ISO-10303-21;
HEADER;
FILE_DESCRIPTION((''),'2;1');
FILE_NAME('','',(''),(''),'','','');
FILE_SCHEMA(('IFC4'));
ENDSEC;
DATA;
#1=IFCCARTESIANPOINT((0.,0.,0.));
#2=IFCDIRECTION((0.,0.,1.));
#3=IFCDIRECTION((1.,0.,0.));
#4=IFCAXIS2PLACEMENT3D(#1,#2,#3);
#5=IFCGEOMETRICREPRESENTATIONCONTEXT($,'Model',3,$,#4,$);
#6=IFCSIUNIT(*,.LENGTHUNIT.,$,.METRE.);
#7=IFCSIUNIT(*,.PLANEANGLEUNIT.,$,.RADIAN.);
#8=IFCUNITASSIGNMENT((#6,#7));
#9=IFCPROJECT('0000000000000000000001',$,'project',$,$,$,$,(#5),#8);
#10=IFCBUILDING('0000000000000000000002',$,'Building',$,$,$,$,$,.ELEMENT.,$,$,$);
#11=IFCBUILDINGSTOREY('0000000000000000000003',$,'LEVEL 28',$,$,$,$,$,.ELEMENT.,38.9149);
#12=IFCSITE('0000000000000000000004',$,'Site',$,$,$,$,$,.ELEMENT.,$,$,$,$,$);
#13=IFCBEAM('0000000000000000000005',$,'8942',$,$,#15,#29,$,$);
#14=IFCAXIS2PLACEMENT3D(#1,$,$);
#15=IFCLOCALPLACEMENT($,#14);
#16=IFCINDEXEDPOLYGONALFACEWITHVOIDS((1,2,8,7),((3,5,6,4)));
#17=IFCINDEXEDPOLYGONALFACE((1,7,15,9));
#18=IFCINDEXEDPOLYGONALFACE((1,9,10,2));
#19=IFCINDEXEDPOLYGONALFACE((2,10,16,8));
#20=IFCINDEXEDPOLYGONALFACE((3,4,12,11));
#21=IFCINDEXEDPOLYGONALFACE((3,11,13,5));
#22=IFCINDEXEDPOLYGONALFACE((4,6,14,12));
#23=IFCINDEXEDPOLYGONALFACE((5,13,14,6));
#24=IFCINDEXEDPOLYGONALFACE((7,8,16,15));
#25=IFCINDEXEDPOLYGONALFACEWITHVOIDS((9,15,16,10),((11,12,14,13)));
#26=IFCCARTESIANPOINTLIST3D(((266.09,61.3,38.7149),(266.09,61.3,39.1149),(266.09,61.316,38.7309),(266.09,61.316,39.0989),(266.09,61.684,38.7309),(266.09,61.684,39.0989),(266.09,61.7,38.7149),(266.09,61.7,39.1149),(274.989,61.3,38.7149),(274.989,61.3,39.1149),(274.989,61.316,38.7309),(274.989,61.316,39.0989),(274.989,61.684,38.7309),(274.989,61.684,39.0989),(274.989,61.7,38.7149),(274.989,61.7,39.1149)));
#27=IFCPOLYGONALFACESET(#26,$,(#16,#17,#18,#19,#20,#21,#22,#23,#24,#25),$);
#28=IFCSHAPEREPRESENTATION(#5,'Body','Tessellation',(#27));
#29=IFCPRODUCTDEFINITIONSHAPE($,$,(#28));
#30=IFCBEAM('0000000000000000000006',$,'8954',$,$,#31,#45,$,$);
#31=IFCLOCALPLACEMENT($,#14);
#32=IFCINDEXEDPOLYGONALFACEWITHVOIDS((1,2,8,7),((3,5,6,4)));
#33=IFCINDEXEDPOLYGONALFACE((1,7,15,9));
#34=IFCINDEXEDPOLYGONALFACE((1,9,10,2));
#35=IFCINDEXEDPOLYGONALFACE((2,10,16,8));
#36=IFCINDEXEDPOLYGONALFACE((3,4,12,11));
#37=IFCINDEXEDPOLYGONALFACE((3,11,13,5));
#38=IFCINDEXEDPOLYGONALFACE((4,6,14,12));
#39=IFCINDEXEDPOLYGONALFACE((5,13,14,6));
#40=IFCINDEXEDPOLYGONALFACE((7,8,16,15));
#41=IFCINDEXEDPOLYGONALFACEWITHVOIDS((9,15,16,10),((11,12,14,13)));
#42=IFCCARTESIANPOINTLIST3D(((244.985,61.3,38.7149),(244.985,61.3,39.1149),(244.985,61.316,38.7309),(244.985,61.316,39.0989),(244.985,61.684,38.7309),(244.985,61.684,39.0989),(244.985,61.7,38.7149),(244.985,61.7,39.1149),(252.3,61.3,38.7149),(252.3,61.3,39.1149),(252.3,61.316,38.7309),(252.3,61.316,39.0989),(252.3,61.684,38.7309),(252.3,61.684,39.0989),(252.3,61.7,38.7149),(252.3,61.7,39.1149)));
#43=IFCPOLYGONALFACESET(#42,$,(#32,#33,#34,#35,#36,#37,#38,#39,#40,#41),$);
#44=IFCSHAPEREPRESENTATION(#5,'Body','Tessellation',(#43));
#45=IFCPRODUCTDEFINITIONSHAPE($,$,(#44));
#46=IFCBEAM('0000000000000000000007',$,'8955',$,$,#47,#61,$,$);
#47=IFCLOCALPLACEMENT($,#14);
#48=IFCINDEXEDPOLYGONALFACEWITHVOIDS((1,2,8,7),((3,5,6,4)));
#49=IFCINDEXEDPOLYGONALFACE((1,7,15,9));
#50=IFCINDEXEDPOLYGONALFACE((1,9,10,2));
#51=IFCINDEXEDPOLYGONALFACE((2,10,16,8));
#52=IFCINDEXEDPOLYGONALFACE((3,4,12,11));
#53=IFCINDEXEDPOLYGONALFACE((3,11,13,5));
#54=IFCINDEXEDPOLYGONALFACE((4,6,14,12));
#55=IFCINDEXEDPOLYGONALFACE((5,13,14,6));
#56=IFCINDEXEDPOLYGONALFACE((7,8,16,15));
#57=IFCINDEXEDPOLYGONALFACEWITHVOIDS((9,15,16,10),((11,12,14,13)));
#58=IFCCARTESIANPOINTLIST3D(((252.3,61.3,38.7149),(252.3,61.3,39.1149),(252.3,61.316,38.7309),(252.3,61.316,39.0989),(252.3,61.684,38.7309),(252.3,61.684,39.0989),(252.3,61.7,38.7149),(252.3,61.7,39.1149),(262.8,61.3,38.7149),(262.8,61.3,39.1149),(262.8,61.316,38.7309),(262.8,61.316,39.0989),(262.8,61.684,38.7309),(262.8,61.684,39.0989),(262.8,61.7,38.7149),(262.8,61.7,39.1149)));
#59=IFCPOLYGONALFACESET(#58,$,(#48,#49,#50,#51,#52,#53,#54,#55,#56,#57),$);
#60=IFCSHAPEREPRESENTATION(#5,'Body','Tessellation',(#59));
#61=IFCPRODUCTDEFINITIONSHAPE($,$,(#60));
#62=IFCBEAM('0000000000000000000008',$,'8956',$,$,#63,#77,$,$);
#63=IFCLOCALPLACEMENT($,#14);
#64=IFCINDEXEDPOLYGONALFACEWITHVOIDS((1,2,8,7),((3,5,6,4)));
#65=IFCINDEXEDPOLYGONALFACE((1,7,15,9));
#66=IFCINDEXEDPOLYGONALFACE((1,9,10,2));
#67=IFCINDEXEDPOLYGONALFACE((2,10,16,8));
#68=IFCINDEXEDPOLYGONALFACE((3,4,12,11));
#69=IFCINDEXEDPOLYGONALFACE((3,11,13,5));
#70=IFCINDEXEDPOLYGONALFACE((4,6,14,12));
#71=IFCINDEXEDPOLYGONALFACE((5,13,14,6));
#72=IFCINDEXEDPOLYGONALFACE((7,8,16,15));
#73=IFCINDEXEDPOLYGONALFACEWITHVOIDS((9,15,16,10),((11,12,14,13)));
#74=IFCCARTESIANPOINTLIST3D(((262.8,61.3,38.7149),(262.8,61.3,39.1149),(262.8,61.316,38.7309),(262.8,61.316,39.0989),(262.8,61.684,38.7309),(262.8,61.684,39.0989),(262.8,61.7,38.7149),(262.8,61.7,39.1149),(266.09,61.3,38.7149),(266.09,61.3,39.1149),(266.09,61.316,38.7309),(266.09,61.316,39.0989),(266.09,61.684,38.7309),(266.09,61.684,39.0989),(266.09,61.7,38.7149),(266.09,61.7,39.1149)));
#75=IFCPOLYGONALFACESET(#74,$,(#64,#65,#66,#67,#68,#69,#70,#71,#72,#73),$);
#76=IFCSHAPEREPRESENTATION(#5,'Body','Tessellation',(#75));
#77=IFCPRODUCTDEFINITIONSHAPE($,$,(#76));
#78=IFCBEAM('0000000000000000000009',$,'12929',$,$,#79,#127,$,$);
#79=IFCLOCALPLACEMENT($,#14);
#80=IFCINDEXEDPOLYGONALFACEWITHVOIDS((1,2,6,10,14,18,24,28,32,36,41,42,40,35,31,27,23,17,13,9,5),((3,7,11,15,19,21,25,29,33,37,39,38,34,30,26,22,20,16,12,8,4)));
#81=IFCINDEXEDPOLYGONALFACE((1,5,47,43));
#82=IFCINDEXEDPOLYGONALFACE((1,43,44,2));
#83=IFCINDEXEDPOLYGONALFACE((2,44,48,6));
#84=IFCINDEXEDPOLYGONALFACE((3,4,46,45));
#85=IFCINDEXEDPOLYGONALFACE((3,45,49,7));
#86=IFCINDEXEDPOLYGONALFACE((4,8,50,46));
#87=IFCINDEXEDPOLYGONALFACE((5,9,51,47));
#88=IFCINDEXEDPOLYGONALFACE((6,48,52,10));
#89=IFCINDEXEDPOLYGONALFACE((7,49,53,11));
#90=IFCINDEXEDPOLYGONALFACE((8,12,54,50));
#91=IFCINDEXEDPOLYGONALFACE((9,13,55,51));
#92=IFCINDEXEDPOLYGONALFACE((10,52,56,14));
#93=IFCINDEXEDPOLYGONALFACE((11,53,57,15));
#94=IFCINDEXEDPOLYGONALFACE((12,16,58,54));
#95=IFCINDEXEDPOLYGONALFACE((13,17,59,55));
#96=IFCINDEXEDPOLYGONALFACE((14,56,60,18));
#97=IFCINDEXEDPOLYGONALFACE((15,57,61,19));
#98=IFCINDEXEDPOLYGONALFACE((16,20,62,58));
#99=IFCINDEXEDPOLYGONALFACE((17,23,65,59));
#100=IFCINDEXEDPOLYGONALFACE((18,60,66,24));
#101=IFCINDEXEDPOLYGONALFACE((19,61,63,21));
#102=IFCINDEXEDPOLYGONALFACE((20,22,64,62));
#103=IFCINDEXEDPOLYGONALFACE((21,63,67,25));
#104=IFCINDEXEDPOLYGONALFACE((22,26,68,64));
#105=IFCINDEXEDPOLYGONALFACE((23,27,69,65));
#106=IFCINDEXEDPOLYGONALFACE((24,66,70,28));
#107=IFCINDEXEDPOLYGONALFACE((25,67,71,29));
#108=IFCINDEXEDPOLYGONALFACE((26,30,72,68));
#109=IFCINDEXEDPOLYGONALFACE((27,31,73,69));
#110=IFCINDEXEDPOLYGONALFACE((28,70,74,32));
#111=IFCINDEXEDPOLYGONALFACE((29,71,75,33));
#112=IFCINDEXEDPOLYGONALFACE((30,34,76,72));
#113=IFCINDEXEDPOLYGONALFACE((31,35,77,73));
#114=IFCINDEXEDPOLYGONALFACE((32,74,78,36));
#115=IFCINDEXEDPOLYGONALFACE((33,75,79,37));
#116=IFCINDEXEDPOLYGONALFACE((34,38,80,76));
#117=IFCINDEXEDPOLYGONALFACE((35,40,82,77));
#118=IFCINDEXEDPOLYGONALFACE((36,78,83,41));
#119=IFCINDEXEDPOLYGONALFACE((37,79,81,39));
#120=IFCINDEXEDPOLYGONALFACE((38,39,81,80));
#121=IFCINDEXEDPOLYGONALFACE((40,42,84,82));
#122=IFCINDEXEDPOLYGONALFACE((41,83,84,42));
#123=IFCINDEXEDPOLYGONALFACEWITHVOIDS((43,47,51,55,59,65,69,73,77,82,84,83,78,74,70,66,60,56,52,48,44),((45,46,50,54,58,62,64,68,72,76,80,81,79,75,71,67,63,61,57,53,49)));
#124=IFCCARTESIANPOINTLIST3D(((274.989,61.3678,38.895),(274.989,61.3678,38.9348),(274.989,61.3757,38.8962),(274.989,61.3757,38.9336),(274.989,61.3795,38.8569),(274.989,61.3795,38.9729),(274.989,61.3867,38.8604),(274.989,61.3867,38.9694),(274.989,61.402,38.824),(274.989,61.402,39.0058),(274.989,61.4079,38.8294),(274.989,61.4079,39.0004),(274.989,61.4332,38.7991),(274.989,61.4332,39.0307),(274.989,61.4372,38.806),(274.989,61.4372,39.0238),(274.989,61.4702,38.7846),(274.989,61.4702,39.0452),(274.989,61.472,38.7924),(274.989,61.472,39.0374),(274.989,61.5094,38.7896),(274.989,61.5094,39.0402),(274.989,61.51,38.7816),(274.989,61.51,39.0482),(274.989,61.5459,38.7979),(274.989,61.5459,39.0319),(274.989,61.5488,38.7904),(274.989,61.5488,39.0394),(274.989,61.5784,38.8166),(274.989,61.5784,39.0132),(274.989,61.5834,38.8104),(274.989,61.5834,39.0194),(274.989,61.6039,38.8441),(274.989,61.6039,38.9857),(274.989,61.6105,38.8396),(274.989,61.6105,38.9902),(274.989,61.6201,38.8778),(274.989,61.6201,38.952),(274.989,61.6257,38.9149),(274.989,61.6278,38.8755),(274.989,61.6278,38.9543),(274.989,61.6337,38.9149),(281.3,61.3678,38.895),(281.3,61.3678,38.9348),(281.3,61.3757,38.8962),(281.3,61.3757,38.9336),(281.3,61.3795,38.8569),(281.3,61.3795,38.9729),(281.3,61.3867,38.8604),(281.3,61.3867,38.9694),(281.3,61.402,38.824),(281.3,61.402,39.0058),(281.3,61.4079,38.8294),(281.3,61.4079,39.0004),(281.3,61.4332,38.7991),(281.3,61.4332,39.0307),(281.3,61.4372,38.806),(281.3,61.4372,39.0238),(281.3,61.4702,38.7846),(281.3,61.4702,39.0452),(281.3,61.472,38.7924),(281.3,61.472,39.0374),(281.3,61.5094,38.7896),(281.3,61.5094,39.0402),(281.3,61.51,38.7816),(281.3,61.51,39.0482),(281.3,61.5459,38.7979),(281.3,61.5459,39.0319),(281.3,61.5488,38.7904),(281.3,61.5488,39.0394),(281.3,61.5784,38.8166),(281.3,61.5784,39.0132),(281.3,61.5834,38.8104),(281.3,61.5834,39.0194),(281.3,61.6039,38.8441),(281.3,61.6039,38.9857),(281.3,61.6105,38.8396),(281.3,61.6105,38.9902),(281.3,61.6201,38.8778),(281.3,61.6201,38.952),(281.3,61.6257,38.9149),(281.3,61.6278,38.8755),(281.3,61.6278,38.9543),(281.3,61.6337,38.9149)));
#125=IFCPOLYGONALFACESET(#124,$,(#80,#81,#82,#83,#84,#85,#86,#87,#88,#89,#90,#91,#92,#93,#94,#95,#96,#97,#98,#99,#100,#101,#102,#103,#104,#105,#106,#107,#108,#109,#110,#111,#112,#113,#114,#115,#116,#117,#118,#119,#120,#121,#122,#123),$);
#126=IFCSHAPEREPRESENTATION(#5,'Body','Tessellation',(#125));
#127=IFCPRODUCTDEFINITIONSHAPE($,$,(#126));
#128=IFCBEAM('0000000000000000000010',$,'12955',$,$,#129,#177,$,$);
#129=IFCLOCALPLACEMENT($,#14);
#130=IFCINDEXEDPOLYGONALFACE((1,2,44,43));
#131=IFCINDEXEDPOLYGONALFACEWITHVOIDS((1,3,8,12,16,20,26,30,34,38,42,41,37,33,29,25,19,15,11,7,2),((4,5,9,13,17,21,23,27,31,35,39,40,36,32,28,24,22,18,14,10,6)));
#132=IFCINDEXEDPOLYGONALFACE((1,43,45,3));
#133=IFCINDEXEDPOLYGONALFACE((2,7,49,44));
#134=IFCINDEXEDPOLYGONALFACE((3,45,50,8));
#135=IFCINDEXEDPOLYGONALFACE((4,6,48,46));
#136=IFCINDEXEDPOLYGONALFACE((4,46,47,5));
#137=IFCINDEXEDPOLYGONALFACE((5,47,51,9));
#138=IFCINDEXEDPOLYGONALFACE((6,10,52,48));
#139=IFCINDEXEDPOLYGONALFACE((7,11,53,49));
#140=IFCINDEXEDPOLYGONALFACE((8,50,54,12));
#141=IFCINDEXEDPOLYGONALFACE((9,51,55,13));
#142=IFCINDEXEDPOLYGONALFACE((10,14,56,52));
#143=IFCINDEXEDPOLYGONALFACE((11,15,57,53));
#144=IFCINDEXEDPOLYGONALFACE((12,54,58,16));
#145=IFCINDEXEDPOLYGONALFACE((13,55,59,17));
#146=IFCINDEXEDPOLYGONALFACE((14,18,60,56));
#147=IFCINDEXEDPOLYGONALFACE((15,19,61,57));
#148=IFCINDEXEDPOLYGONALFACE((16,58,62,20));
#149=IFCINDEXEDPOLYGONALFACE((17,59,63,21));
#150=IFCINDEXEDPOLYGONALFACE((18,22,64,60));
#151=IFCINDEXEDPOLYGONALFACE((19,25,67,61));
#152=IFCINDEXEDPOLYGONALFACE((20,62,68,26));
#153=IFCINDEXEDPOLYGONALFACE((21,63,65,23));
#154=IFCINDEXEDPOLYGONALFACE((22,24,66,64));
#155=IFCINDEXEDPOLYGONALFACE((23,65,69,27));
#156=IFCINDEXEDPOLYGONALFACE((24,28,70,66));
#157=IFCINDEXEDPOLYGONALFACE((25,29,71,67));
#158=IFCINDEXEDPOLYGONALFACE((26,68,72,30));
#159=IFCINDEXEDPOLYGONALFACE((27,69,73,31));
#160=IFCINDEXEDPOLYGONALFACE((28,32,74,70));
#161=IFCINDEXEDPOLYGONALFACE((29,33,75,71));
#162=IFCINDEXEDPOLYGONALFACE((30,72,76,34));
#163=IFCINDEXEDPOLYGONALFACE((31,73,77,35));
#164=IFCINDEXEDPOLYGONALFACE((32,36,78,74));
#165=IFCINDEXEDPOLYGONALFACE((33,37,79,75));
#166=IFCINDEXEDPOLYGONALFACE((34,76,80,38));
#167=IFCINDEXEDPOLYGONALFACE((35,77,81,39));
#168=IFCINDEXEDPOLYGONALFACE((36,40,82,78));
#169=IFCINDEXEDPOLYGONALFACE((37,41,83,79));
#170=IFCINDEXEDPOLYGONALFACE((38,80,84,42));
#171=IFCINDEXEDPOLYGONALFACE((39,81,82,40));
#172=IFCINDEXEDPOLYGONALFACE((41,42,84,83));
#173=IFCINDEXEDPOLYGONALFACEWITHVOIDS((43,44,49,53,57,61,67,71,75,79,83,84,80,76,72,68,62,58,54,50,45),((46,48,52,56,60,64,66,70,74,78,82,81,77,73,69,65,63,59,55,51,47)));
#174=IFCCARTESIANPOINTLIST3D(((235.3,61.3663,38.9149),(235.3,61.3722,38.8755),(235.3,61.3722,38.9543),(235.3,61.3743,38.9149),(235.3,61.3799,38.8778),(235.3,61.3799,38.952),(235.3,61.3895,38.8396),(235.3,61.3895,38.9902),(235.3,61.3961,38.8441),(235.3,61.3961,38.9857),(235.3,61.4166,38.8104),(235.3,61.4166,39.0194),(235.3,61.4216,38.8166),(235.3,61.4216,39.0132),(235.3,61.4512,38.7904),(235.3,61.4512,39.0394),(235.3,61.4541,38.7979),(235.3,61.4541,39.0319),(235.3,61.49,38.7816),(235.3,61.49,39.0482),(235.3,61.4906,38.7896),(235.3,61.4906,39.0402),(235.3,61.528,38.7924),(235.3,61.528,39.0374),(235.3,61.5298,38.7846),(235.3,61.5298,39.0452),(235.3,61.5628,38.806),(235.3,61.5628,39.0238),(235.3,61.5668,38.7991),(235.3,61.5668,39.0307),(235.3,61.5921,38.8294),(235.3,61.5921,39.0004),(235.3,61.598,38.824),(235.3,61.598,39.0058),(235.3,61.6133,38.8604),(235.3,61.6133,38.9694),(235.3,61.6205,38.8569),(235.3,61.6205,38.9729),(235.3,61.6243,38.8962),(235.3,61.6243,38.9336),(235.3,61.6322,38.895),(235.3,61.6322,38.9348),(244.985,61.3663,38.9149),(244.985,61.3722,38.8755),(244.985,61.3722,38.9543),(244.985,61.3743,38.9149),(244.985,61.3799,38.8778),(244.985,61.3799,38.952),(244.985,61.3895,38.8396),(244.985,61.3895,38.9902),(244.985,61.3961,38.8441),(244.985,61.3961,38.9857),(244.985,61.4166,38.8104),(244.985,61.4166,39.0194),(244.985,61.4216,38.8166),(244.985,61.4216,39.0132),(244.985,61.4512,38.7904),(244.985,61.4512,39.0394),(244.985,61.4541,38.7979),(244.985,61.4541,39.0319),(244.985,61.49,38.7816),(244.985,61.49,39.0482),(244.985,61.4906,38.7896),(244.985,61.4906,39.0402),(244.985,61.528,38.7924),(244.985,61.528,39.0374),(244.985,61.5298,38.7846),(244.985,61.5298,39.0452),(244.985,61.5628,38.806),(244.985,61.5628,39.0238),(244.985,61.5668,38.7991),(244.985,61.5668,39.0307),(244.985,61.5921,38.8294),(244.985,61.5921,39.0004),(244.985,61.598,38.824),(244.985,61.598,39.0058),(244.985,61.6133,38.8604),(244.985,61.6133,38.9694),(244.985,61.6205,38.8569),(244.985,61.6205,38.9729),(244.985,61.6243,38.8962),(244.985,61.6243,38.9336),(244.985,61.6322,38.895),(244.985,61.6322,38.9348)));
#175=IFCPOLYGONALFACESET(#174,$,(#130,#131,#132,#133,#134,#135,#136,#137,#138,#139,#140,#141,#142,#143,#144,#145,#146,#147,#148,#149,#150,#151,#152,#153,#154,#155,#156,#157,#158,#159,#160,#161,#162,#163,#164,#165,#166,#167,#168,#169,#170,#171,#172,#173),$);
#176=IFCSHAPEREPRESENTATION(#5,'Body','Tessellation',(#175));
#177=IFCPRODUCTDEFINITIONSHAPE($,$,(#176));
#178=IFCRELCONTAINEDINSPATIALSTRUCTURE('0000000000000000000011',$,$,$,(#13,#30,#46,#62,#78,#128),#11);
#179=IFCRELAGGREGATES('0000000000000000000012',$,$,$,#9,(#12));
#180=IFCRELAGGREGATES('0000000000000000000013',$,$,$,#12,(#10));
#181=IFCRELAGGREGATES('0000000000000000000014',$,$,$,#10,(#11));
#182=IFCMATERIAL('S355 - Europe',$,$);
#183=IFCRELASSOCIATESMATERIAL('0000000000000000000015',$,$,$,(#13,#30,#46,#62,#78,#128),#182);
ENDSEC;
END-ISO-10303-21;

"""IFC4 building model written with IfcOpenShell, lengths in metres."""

from ifc_helpers import new_model, si_unit, frame, origin_with_axes, origin_2d_with_axis, place, context, project, spatial, hollow_rectangle, hollow_circle, extrude, material, material_profile, profile_set, profile_usage, element, save


model = new_model("IFC4")

# Units and contexts
model_context = context("Model", 3, world=origin_with_axes())
ifc_project = project(units=[si_unit("LENGTHUNIT", "METRE"), si_unit("PLANEANGLEUNIT", "RADIAN")], contexts=[model_context])

# Site, building, storey
site = spatial("IfcSite", under=ifc_project, Name="Site", CompositionType="ELEMENT")
building = spatial("IfcBuilding", under=site, Name="Building", CompositionType="ELEMENT")
storey = spatial("IfcBuildingStorey", under=building, Name="LEVEL 28", CompositionType="ELEMENT", Elevation=38.9149)

# Beams
ifc_material = material(Name="S355 - Europe")
ifc_material_profile_1 = material_profile(ifc_material, hollow_rectangle(XDim=0.4, YDim=0.4, WallThickness=0.016, at=origin_2d_with_axis()))
ifc_profile_set_1 = profile_set([ifc_material_profile_1])
ifc_profile_usage_1 = profile_usage(ifc_profile_set_1, cardinal=10)
beam_1_placement = place(None, frame((274.989, 61.5, 38.9149), z_axis=(-1.0, 0.0, 0.0), x_axis=(0.0, -1.0, 0.0)))
element("IfcBeam", 1, at=beam_1_placement, inside=storey, material=ifc_profile_usage_1, Name="8942", context=model_context, shape_type="SweptSolid", body=[
    extrude(hollow_rectangle(XDim=0.4, YDim=0.4, WallThickness=0.016, at=origin_2d_with_axis()), origin_with_axes(), (0.0, 0.0, 1.0), 8.899),
])
ifc_material_profile_2 = material_profile(ifc_material, hollow_rectangle(XDim=0.4, YDim=0.4, WallThickness=0.016, at=origin_2d_with_axis()))
ifc_profile_set_2 = profile_set([ifc_material_profile_2])
ifc_profile_usage_2 = profile_usage(ifc_profile_set_2, cardinal=10)
beam_2_placement = place(None, frame((252.3, 61.5, 38.9149), z_axis=(-1.0, 0.0, 0.0), x_axis=(0.0, -1.0, 0.0)))
element("IfcBeam", 2, at=beam_2_placement, inside=storey, material=ifc_profile_usage_2, Name="8954", context=model_context, shape_type="SweptSolid", body=[
    extrude(hollow_rectangle(XDim=0.4, YDim=0.4, WallThickness=0.016, at=origin_2d_with_axis()), origin_with_axes(), (0.0, 0.0, 1.0), 7.315),
])
ifc_material_profile_3 = material_profile(ifc_material, hollow_rectangle(XDim=0.4, YDim=0.4, WallThickness=0.016, at=origin_2d_with_axis()))
ifc_profile_set_3 = profile_set([ifc_material_profile_3])
ifc_profile_usage_3 = profile_usage(ifc_profile_set_3, cardinal=10)
beam_3_placement = place(None, frame((262.8, 61.5, 38.9149), z_axis=(-1.0, 0.0, 0.0), x_axis=(0.0, -1.0, 0.0)))
element("IfcBeam", 3, at=beam_3_placement, inside=storey, material=ifc_profile_usage_3, Name="8955", context=model_context, shape_type="SweptSolid", body=[
    extrude(hollow_rectangle(XDim=0.4, YDim=0.4, WallThickness=0.016, at=origin_2d_with_axis()), origin_with_axes(), (0.0, 0.0, 1.0), 10.5),
])
ifc_material_profile_4 = material_profile(ifc_material, hollow_rectangle(XDim=0.4, YDim=0.4, WallThickness=0.016, at=origin_2d_with_axis()))
ifc_profile_set_4 = profile_set([ifc_material_profile_4])
ifc_profile_usage_4 = profile_usage(ifc_profile_set_4, cardinal=10)
beam_4_placement = place(None, frame((266.09, 61.5, 38.9149), z_axis=(-1.0, 0.0, 0.0), x_axis=(0.0, -1.0, 0.0)))
element("IfcBeam", 4, at=beam_4_placement, inside=storey, material=ifc_profile_usage_4, Name="8956", context=model_context, shape_type="SweptSolid", body=[
    extrude(hollow_rectangle(XDim=0.4, YDim=0.4, WallThickness=0.016, at=origin_2d_with_axis()), origin_with_axes(), (0.0, 0.0, 1.0), 3.29),
])
ifc_material_profile_5 = material_profile(ifc_material, hollow_circle(Radius=0.1337, WallThickness=0.008, at=origin_2d_with_axis()))
ifc_profile_set_5 = profile_set([ifc_material_profile_5])
ifc_profile_usage_5 = profile_usage(ifc_profile_set_5, cardinal=10)
beam_5_placement = place(None, frame((274.989, 61.5, 38.9149), z_axis=(1.0, 0.0, 0.0), x_axis=(0.0, 1.0, 0.0)))
element("IfcBeam", 5, at=beam_5_placement, inside=storey, material=ifc_profile_usage_5, Name="12929", context=model_context, shape_type="SweptSolid", body=[
    extrude(hollow_circle(Radius=0.1337, WallThickness=0.008, at=origin_2d_with_axis()), origin_with_axes(), (0.0, 0.0, 1.0), 6.311),
])
ifc_material_profile_6 = material_profile(ifc_material, hollow_circle(Radius=0.1337, WallThickness=0.008, at=origin_2d_with_axis()))
ifc_profile_set_6 = profile_set([ifc_material_profile_6])
ifc_profile_usage_6 = profile_usage(ifc_profile_set_6, cardinal=10)
beam_6_placement = place(None, frame((244.985, 61.5, 38.9149), z_axis=(-1.0, 0.0, 0.0), x_axis=(0.0, -1.0, 0.0)))
element("IfcBeam", 6, at=beam_6_placement, inside=storey, material=ifc_profile_usage_6, Name="12955", context=model_context, shape_type="SweptSolid", body=[
    extrude(hollow_circle(Radius=0.1337, WallThickness=0.008, at=origin_2d_with_axis()), origin_with_axes(), (0.0, 0.0, 1.0), 9.685),
])

save(model, "model.ifc")
